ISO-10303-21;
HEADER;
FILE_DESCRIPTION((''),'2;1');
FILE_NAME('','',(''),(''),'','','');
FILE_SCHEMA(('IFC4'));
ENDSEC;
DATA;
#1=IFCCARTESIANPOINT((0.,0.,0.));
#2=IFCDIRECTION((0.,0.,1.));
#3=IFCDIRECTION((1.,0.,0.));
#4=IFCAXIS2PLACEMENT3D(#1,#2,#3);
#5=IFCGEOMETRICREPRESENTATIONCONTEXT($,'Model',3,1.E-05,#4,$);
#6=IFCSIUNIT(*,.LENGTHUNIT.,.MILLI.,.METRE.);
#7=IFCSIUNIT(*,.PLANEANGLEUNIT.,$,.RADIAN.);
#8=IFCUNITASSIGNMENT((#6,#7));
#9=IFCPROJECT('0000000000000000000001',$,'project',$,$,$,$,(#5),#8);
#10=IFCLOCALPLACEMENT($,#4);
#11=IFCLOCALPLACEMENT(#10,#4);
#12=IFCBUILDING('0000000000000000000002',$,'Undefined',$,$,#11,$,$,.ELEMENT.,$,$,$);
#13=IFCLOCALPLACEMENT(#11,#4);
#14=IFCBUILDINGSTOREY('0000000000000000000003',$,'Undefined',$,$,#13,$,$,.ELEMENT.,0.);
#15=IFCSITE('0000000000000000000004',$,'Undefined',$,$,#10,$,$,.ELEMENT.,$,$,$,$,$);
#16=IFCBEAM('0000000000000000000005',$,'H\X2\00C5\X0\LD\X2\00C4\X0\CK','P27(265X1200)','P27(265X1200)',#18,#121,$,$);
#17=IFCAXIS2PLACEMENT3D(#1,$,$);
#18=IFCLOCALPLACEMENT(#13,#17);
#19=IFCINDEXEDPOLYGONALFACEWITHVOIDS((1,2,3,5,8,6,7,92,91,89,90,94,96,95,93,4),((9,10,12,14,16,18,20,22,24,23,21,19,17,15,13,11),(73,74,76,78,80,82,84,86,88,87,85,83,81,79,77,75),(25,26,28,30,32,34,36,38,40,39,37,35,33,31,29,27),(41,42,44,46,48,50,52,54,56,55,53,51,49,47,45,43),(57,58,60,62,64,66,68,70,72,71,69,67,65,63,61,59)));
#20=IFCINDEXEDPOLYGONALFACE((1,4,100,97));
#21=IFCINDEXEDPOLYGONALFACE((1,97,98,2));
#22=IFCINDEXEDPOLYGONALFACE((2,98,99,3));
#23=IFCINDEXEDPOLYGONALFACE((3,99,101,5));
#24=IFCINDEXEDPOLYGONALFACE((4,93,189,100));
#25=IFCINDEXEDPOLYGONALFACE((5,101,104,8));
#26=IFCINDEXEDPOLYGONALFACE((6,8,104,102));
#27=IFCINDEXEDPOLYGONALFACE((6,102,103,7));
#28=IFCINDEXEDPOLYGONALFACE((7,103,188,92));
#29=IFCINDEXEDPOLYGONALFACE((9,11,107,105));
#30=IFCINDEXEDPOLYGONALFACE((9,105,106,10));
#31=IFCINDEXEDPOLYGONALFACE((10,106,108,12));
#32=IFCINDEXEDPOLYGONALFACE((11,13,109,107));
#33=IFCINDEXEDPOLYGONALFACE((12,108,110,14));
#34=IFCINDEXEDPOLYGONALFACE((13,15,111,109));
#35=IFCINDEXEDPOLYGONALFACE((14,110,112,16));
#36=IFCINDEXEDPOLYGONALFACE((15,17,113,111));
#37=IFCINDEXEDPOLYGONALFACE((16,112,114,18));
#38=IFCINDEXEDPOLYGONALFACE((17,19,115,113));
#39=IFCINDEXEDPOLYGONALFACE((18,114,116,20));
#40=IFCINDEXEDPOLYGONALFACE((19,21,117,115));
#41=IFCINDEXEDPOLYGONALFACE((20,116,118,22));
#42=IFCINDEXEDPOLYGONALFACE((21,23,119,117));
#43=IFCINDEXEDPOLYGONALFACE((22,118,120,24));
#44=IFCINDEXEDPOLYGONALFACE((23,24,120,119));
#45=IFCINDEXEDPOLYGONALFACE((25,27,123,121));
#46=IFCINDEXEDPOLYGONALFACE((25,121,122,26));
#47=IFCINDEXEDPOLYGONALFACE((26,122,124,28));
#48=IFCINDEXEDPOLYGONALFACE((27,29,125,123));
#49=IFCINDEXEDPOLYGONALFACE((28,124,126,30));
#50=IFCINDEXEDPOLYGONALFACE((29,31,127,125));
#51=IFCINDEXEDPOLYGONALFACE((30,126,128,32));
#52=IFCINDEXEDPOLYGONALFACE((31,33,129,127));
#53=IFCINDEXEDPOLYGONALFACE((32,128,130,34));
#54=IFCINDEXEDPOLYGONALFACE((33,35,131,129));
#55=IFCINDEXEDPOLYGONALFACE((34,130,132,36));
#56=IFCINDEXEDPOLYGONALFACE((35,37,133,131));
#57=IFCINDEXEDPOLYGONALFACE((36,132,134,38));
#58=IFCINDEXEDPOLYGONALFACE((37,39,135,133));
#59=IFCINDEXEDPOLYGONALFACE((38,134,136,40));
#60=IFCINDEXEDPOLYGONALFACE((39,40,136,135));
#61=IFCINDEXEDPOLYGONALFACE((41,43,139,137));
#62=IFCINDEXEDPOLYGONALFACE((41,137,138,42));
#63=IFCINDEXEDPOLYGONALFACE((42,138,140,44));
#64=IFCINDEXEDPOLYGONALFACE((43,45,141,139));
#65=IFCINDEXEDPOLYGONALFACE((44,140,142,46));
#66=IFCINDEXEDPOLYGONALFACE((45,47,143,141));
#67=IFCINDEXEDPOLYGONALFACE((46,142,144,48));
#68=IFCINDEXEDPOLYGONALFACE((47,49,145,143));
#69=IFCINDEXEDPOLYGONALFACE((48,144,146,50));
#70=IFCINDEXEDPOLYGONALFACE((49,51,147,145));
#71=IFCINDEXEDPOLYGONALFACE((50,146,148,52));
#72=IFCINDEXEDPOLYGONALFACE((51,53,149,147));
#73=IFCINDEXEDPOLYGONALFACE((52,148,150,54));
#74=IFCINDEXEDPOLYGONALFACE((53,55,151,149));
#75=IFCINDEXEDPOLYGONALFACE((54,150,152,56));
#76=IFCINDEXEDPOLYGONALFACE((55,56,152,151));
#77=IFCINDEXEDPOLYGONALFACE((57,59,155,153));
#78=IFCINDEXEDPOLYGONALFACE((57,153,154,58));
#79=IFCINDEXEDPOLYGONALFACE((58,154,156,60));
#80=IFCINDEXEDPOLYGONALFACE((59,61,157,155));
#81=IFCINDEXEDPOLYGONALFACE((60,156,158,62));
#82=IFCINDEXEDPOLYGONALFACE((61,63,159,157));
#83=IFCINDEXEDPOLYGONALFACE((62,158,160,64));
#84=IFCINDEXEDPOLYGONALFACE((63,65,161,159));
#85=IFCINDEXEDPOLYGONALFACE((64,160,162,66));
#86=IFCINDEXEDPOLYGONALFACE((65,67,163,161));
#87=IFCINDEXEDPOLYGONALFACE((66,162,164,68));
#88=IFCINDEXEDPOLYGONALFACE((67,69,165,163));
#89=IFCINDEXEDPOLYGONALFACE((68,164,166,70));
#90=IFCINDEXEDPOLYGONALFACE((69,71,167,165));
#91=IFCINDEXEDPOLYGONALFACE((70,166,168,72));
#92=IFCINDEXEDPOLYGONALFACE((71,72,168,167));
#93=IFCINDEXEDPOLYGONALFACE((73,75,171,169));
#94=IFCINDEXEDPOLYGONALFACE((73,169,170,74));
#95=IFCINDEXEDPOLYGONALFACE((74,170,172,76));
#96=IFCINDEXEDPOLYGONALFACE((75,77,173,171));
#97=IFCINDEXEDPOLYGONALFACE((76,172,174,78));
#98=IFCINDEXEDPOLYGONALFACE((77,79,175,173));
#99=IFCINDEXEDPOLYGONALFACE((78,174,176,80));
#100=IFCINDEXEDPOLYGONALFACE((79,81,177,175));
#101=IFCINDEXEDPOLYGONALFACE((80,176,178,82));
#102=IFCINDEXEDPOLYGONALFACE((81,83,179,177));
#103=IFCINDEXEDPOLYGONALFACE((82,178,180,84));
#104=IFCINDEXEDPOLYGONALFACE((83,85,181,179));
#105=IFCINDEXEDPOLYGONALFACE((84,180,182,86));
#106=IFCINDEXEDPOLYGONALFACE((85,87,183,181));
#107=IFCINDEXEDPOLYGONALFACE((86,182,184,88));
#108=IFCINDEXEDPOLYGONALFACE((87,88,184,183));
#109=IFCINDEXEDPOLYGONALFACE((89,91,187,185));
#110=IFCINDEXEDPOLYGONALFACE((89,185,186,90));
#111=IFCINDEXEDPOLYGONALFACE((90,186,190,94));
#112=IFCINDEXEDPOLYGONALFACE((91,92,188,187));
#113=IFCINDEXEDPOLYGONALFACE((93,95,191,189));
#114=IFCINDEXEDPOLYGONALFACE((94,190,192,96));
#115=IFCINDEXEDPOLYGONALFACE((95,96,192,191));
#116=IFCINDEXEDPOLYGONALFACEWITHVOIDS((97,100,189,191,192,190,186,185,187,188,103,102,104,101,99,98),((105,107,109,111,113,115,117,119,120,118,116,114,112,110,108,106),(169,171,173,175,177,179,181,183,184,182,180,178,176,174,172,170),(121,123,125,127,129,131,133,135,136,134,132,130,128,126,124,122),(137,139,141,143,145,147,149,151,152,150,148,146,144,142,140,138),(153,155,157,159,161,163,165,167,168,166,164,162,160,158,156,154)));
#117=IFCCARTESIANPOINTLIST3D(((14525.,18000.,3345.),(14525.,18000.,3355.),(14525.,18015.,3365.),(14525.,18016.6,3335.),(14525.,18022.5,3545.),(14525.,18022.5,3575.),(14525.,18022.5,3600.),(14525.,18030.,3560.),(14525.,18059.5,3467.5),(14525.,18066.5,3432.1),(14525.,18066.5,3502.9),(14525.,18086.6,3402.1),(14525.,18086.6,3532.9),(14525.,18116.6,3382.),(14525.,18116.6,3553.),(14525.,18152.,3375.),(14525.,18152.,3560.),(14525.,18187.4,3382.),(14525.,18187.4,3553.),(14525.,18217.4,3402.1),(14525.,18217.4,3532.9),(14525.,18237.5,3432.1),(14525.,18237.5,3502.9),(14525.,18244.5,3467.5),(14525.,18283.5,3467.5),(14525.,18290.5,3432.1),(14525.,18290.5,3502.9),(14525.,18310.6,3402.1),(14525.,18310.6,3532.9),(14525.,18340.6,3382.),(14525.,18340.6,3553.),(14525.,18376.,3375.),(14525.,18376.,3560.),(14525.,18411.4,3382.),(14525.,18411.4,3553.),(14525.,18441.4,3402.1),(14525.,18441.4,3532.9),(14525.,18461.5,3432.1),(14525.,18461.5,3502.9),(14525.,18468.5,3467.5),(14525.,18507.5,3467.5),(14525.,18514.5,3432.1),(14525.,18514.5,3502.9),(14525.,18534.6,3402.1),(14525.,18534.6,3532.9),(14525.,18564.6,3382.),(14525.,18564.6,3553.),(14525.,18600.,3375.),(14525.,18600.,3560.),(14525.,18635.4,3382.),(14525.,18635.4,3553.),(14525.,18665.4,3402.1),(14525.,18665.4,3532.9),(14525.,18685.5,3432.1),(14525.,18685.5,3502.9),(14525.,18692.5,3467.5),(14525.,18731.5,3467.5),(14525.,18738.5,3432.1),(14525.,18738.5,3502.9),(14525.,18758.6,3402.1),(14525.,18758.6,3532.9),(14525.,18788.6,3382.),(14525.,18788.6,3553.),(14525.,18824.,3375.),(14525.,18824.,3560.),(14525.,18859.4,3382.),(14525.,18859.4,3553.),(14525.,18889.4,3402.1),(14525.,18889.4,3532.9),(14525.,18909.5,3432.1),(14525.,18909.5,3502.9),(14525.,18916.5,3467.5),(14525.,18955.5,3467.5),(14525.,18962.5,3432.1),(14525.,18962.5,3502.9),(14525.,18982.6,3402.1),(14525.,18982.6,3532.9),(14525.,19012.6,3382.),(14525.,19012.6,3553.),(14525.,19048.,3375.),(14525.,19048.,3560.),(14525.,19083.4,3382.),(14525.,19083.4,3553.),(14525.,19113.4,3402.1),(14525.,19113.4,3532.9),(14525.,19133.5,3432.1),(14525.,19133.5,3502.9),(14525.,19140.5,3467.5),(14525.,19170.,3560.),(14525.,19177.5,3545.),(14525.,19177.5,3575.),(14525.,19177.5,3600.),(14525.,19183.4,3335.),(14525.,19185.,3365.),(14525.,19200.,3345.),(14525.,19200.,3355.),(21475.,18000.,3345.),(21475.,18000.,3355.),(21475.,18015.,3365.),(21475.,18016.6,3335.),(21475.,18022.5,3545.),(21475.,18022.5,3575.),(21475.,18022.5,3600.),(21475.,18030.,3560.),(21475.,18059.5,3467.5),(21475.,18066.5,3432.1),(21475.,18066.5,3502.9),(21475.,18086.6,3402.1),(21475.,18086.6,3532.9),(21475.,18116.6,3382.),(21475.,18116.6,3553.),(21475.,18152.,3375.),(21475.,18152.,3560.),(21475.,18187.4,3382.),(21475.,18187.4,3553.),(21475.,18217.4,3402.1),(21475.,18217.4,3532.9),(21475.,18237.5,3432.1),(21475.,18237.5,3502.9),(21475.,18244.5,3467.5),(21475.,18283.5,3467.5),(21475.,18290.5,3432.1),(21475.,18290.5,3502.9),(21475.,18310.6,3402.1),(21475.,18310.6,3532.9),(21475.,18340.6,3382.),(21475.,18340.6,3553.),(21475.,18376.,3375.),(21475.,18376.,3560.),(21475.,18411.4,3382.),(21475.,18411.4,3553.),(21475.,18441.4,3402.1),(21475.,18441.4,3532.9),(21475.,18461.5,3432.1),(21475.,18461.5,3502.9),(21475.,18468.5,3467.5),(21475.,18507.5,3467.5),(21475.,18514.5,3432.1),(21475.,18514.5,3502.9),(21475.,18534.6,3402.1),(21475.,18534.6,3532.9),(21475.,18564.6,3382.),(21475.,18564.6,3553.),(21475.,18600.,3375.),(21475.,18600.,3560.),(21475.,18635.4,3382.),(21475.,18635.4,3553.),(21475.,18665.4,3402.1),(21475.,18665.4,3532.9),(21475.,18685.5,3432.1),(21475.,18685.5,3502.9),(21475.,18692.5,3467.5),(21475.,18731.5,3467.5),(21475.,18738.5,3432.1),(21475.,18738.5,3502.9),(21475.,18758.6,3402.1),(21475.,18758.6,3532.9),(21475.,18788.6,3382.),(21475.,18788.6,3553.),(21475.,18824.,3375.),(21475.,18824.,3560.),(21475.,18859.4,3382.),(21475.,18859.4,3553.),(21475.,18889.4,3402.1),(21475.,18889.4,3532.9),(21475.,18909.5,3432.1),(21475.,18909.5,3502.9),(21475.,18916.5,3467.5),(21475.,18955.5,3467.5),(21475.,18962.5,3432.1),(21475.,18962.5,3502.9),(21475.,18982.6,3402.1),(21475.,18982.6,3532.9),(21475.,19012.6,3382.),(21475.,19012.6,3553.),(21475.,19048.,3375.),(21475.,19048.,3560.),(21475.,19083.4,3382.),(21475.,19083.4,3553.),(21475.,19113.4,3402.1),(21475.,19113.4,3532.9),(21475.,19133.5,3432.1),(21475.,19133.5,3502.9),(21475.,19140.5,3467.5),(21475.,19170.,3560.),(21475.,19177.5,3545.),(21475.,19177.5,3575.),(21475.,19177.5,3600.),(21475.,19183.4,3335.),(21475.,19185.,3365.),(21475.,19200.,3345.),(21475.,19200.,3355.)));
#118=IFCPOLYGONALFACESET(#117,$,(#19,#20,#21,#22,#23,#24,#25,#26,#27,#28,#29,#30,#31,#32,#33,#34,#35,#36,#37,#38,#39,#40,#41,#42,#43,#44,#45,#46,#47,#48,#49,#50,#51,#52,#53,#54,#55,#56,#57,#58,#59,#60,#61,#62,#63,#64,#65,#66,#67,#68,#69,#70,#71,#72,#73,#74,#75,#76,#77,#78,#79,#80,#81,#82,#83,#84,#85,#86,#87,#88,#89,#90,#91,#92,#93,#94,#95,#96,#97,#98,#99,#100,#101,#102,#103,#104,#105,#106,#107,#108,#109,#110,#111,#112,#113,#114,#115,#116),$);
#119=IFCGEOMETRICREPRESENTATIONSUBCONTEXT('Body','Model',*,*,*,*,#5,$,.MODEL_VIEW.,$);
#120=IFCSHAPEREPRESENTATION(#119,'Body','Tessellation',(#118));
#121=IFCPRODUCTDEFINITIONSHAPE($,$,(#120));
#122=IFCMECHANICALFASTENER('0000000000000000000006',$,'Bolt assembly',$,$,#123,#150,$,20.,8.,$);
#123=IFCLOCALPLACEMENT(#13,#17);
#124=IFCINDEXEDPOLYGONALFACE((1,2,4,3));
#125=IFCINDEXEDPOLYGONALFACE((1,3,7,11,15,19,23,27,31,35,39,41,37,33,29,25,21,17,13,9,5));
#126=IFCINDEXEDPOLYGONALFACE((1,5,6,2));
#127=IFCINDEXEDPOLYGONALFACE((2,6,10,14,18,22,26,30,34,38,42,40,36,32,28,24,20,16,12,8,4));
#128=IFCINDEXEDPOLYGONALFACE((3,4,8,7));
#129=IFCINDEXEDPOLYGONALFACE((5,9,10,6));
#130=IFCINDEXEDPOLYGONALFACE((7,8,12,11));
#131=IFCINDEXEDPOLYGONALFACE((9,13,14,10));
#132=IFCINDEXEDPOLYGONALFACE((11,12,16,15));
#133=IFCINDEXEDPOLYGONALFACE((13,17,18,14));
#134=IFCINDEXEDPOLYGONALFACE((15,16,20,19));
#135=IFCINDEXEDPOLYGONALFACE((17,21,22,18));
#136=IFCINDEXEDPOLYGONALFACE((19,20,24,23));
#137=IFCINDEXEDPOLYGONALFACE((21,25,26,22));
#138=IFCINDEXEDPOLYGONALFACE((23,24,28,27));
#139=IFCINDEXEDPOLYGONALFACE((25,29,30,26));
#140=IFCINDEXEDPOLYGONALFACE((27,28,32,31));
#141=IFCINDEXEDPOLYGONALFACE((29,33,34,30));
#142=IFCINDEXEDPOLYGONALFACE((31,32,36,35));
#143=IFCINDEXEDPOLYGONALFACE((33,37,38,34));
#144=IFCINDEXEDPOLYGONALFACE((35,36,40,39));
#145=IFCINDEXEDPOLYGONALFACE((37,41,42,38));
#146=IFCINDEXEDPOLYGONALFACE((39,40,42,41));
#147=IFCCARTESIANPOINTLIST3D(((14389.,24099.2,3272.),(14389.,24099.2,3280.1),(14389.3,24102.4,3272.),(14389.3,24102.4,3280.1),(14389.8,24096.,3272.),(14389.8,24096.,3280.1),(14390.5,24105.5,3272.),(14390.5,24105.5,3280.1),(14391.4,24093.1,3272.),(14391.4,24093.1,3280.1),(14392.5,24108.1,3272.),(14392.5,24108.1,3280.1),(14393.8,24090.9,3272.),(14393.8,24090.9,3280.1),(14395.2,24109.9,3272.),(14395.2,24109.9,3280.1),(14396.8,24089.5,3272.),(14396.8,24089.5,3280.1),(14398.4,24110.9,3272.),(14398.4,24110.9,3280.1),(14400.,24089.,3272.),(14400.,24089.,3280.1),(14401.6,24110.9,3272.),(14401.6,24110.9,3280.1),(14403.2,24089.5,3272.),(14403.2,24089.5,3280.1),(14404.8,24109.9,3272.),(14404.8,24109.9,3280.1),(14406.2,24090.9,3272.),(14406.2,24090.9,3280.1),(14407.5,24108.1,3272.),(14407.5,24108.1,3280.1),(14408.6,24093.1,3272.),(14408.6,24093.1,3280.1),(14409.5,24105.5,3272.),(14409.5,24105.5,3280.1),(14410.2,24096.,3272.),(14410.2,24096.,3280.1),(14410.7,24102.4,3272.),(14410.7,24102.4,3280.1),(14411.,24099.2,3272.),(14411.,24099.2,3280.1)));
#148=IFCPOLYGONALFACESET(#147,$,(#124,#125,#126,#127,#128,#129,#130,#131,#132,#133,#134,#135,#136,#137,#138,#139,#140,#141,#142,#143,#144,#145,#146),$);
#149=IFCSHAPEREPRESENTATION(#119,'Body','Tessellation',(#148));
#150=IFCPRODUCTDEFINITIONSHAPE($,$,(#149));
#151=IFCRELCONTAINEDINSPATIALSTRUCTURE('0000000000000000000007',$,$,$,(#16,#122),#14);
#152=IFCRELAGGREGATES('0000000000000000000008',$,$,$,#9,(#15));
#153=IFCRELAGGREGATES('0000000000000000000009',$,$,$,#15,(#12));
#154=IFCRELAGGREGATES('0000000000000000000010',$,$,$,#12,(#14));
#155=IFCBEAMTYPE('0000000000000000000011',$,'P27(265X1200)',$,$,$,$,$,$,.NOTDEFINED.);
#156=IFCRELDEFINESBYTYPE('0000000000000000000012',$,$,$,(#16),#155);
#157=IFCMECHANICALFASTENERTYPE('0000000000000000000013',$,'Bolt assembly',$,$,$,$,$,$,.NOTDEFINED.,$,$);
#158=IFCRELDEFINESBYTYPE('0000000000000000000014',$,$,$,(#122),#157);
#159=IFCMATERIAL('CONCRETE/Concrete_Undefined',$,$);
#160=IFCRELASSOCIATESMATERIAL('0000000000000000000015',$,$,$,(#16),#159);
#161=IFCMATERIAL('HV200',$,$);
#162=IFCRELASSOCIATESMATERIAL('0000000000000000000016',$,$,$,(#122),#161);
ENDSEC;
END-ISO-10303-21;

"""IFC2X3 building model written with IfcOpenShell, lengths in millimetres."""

from ifc_helpers import new_model, si_unit, frame, origin_with_axes, origin_2d_with_axis, place, context, subcontext, project, spatial, polyline, circle, outline, extrude, source, transform, mapped, material, type_object, element, save


model = new_model("IFC2X3")

# Units and contexts
model_context = context("Model", 3, precision=1e-05, world=origin_with_axes())
body_context = subcontext(model_context, "Body", "Model", "MODEL_VIEW")
ifc_project = project(units=[si_unit("LENGTHUNIT", "METRE", prefix="MILLI"), si_unit("PLANEANGLEUNIT", "RADIAN")], contexts=[model_context])

# Site, building, storey
site_placement = place(None, origin_with_axes())
site = spatial("IfcSite", under=ifc_project, at=site_placement, Name="Undefined", CompositionType="ELEMENT")
building_placement = place(site_placement, origin_with_axes())
building = spatial("IfcBuilding", under=site, at=building_placement, Name="Undefined", CompositionType="ELEMENT")
storey_placement = place(building_placement, origin_with_axes())
storey = spatial("IfcBuildingStorey", under=building, at=storey_placement, Name="Undefined", CompositionType="ELEMENT", Elevation=0.0)

# Beam
ifc_material_1 = material(Name="CONCRETE/Concrete_Undefined")
beam_type_1 = type_object("IfcBeamType", Name="P27(265X1200)", PredefinedType="NOTDEFINED")
beam_1_placement = place(storey_placement, frame((14525.0, 18600.0, 3467.5), z_axis=(0.0, 0.0, 1.0), x_axis=(1.0, 0.0, 0.0)))
element("IfcBeam", 1, at=beam_1_placement, inside=storey, type_object=beam_type_1, material=ifc_material_1, Name="HÅLDÄCK", Description="P27(265X1200)", ObjectType="P27(265X1200)", context=body_context, shape_type="SweptSolid", body=[
    extrude(outline(polyline([(-583.4, -132.5), (-600.0, -122.5), (-600.0, -112.5), (-585.0, -102.5), (-577.5, 77.5), (-570.0, 92.5), (-577.5, 107.5), (-577.5, 132.5), (577.5, 132.5), (577.5, 107.5), (570.0, 92.5), (577.5, 77.5), (585.0, -102.5), (600.0, -112.5), (600.0, -122.5), (583.4, -132.5), (-583.4, -132.5)]), holes=[polyline([(-513.4, 65.4), (-533.5, 35.4), (-540.5, 0.0), (-533.5, -35.4), (-513.4, -65.4), (-483.4, -85.5), (-448.0, -92.5), (-412.6, -85.5), (-382.6, -65.4), (-362.5, -35.4), (-355.5, 0.0), (-362.5, 35.4), (-382.6, 65.4), (-412.6, 85.5), (-448.0, 92.5), (-483.4, 85.5), (-513.4, 65.4)]), polyline([(-289.4, 65.4), (-309.5, 35.4), (-316.5, 0.0), (-309.5, -35.4), (-289.4, -65.4), (-259.4, -85.5), (-224.0, -92.5), (-188.6, -85.5), (-158.6, -65.4), (-138.5, -35.4), (-131.5, 0.0), (-138.5, 35.4), (-158.6, 65.4), (-188.6, 85.5), (-224.0, 92.5), (-259.4, 85.5), (-289.4, 65.4)]), polyline([(-65.4, 65.4), (-85.5, 35.4), (-92.5, 0.0), (-85.5, -35.4), (-65.4, -65.4), (-35.4, -85.5), (0.0, -92.5), (35.4, -85.5), (65.4, -65.4), (85.5, -35.4), (92.5, 0.0), (85.5, 35.4), (65.4, 65.4), (35.4, 85.5), (0.0, 92.5), (-35.4, 85.5), (-65.4, 65.4)]), polyline([(158.6, 65.4), (138.5, 35.4), (131.5, 0.0), (138.5, -35.4), (158.6, -65.4), (188.6, -85.5), (224.0, -92.5), (259.4, -85.5), (289.4, -65.4), (309.5, -35.4), (316.5, 0.0), (309.5, 35.4), (289.4, 65.4), (259.4, 85.5), (224.0, 92.5), (188.6, 85.5), (158.6, 65.4)]), polyline([(382.6, 65.4), (362.5, 35.4), (355.5, 0.0), (362.5, -35.4), (382.6, -65.4), (412.6, -85.5), (448.0, -92.5), (483.4, -85.5), (513.4, -65.4), (533.5, -35.4), (540.5, 0.0), (533.5, 35.4), (513.4, 65.4), (483.4, 85.5), (448.0, 92.5), (412.6, 85.5), (382.6, 65.4)])]), frame((6950.0, 0.0, 0.0), z_axis=(-1.0, 0.0, 0.0), x_axis=(0.0, -1.0, 0.0)), (0.0, 0.0, 1.0), 6950.0),
])

# Mechanical fastener
ifc_material_2 = material(Name="HV200")
mechanical_fastener_type = type_object("IfcMechanicalFastenerType", Name="Bolt assembly")
shared_shape_1 = source(origin_with_axes(), body_context, "Body", "SweptSolid", [
    extrude(circle(Radius=11.0, at=origin_2d_with_axis()), frame((0.0, -8.0, 0.0), z_axis=(0.0, 1.0, 0.0), x_axis=(1.0, 0.0, 0.0)), (0.0, 0.0, 1.0), 8.1),
])
mechanical_fastener_1_placement = place(storey_placement, frame((14400.0, 24100.0, 3280.0), z_axis=(-1.0, 0.0, 0.0), x_axis=(0.0, -1.0, 0.0)))
element("IfcMechanicalFastener", 2, at=mechanical_fastener_1_placement, inside=storey, type_object=mechanical_fastener_type, material=ifc_material_2, Name="Bolt assembly", NominalDiameter=20.0, NominalLength=8.0, context=body_context, shape_type="MappedRepresentation", body=[
    mapped(shared_shape_1, transform((0.0, 0.0, 0.0))),
])

save(model, "model.ifc")
